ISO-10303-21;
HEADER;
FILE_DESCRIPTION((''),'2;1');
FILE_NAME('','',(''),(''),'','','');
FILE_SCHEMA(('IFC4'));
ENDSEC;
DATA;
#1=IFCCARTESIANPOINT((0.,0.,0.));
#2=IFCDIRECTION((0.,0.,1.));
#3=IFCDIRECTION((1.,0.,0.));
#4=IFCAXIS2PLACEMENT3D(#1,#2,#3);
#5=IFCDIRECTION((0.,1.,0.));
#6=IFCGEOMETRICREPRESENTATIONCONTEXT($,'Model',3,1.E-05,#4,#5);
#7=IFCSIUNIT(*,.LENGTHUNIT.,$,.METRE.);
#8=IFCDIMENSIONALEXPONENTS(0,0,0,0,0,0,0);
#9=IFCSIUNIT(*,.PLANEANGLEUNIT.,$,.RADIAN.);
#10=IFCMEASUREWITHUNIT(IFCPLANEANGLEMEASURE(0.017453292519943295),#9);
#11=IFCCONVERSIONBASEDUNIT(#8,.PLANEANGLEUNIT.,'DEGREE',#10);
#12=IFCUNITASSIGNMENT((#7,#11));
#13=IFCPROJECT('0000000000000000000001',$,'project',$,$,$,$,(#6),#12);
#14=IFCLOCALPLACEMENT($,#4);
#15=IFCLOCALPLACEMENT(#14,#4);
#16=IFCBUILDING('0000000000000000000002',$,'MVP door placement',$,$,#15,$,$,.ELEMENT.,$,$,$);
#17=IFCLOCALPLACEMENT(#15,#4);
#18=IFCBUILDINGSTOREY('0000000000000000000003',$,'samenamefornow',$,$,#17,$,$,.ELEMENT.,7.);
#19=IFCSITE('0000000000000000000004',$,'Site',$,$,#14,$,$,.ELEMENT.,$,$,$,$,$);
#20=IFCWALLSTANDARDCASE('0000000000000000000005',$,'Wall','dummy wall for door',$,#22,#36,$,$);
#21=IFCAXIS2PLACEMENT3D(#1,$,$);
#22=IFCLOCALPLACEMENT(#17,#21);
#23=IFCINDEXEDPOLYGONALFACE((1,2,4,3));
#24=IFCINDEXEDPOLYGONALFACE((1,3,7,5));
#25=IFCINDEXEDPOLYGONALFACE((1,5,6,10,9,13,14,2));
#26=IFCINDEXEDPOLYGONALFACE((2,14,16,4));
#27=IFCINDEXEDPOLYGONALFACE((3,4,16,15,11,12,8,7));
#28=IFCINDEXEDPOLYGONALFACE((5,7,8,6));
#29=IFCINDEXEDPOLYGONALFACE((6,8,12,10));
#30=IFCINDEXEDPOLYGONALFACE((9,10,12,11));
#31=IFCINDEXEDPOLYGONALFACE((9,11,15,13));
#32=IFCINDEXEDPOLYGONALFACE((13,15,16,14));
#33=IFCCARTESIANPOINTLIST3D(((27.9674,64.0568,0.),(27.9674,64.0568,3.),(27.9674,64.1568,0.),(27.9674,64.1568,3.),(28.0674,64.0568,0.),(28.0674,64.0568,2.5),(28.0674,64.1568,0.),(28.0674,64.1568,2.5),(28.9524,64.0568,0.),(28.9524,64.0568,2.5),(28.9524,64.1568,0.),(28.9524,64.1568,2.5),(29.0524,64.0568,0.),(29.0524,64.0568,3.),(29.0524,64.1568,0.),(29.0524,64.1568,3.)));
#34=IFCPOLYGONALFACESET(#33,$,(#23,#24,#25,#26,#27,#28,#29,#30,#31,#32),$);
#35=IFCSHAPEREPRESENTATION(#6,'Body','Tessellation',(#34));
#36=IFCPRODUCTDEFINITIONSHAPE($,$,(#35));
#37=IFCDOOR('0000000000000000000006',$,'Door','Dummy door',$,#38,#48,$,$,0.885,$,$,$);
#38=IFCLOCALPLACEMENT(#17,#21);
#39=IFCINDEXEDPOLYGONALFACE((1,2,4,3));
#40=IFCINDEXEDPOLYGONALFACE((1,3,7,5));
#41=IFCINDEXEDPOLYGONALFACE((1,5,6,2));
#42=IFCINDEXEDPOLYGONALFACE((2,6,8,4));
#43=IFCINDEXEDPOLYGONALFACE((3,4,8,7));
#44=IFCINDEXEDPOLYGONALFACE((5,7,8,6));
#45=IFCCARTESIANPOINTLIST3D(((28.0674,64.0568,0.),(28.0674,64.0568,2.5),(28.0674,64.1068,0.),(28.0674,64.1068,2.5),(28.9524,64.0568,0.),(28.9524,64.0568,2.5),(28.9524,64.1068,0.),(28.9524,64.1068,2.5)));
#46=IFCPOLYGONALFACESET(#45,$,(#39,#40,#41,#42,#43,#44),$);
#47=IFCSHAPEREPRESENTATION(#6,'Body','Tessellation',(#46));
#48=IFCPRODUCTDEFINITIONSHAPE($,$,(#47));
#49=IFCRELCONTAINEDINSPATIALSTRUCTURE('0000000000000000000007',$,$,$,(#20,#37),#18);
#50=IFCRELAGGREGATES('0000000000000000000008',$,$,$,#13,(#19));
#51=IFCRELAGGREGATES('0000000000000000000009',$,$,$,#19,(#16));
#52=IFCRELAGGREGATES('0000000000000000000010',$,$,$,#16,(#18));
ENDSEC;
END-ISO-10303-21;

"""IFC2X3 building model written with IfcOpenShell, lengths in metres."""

from ifc_helpers import new_model, entity, si_unit, converted_unit, direction, origin_with_axes, place, context, project, spatial, polyline, outline, extrude, element, fill, save


model = new_model("IFC2X3")

# Units and contexts
model_context = context("Model", 3, precision=1e-05, world=origin_with_axes(), true_north=direction((0.0, 1.0, 0.0)))
ifc_project = project(units=[si_unit("LENGTHUNIT", "METRE"), converted_unit("PLANEANGLEUNIT", "DEGREE", entity("IfcPlaneAngleMeasure", 0.017453292519943295), si_unit("PLANEANGLEUNIT", "RADIAN"), dimensions=[0, 0, 0, 0, 0, 0, 0])], contexts=[model_context])

# Site, building, storey
site_placement = place(None, origin_with_axes())
site = spatial("IfcSite", under=ifc_project, at=site_placement, Name="Site", CompositionType="ELEMENT")
building_placement = place(site_placement, origin_with_axes())
building = spatial("IfcBuilding", under=site, at=building_placement, Name="MVP door placement", CompositionType="ELEMENT")
storey_placement = place(building_placement, origin_with_axes())
storey = spatial("IfcBuildingStorey", under=building, at=storey_placement, Name="samenamefornow", CompositionType="ELEMENT", Elevation=7.0)

# Wall, opening, door
wall_1_placement = place(storey_placement, origin_with_axes())
wall_1 = element("IfcWallStandardCase", 1, at=wall_1_placement, inside=storey, Name="Wall", Description="dummy wall for door", context=model_context, shape_type="SweptSolid", body=[
    extrude(outline(polyline([(27.9674, 64.0568, 0.0), (29.0524, 64.0568, 0.0), (29.0524, 64.1568, 0.0), (27.9674, 64.1568, 0.0), (27.9674, 64.0568, 0.0)])), origin_with_axes(), (0.0, 0.0, 1.0), 3.0),
])
opening_1_placement = place(wall_1_placement, origin_with_axes())
opening_1 = element("IfcOpeningElement", 2, at=opening_1_placement, cuts=wall_1, context=model_context, shape_type="SweptSolid", body=[
    extrude(outline(polyline([(28.0674, 64.0568, 0.0), (28.9524, 64.0568, 0.0), (28.9524, 64.1568, 0.0), (28.0674, 64.1568, 0.0), (28.0674, 64.0568, 0.0)])), origin_with_axes(), (0.0, 0.0, 1.0), 2.5),
])
door_1_placement = place(opening_1_placement, origin_with_axes())
door_1 = element("IfcDoor", 3, at=door_1_placement, inside=storey, Name="Door", Description="Dummy door", OverallWidth=0.885, context=model_context, shape_type="SweptSolid", body=[
    extrude(outline(polyline([(28.0674, 64.0568, 0.0), (28.9524, 64.0568, 0.0), (28.9524, 64.1068, 0.0), (28.0674, 64.1068, 0.0), (28.0674, 64.0568, 0.0)])), origin_with_axes(), (0.0, 0.0, 1.0), 2.5),
])
fill(opening_1, door_1)

save(model, "model.ifc")
